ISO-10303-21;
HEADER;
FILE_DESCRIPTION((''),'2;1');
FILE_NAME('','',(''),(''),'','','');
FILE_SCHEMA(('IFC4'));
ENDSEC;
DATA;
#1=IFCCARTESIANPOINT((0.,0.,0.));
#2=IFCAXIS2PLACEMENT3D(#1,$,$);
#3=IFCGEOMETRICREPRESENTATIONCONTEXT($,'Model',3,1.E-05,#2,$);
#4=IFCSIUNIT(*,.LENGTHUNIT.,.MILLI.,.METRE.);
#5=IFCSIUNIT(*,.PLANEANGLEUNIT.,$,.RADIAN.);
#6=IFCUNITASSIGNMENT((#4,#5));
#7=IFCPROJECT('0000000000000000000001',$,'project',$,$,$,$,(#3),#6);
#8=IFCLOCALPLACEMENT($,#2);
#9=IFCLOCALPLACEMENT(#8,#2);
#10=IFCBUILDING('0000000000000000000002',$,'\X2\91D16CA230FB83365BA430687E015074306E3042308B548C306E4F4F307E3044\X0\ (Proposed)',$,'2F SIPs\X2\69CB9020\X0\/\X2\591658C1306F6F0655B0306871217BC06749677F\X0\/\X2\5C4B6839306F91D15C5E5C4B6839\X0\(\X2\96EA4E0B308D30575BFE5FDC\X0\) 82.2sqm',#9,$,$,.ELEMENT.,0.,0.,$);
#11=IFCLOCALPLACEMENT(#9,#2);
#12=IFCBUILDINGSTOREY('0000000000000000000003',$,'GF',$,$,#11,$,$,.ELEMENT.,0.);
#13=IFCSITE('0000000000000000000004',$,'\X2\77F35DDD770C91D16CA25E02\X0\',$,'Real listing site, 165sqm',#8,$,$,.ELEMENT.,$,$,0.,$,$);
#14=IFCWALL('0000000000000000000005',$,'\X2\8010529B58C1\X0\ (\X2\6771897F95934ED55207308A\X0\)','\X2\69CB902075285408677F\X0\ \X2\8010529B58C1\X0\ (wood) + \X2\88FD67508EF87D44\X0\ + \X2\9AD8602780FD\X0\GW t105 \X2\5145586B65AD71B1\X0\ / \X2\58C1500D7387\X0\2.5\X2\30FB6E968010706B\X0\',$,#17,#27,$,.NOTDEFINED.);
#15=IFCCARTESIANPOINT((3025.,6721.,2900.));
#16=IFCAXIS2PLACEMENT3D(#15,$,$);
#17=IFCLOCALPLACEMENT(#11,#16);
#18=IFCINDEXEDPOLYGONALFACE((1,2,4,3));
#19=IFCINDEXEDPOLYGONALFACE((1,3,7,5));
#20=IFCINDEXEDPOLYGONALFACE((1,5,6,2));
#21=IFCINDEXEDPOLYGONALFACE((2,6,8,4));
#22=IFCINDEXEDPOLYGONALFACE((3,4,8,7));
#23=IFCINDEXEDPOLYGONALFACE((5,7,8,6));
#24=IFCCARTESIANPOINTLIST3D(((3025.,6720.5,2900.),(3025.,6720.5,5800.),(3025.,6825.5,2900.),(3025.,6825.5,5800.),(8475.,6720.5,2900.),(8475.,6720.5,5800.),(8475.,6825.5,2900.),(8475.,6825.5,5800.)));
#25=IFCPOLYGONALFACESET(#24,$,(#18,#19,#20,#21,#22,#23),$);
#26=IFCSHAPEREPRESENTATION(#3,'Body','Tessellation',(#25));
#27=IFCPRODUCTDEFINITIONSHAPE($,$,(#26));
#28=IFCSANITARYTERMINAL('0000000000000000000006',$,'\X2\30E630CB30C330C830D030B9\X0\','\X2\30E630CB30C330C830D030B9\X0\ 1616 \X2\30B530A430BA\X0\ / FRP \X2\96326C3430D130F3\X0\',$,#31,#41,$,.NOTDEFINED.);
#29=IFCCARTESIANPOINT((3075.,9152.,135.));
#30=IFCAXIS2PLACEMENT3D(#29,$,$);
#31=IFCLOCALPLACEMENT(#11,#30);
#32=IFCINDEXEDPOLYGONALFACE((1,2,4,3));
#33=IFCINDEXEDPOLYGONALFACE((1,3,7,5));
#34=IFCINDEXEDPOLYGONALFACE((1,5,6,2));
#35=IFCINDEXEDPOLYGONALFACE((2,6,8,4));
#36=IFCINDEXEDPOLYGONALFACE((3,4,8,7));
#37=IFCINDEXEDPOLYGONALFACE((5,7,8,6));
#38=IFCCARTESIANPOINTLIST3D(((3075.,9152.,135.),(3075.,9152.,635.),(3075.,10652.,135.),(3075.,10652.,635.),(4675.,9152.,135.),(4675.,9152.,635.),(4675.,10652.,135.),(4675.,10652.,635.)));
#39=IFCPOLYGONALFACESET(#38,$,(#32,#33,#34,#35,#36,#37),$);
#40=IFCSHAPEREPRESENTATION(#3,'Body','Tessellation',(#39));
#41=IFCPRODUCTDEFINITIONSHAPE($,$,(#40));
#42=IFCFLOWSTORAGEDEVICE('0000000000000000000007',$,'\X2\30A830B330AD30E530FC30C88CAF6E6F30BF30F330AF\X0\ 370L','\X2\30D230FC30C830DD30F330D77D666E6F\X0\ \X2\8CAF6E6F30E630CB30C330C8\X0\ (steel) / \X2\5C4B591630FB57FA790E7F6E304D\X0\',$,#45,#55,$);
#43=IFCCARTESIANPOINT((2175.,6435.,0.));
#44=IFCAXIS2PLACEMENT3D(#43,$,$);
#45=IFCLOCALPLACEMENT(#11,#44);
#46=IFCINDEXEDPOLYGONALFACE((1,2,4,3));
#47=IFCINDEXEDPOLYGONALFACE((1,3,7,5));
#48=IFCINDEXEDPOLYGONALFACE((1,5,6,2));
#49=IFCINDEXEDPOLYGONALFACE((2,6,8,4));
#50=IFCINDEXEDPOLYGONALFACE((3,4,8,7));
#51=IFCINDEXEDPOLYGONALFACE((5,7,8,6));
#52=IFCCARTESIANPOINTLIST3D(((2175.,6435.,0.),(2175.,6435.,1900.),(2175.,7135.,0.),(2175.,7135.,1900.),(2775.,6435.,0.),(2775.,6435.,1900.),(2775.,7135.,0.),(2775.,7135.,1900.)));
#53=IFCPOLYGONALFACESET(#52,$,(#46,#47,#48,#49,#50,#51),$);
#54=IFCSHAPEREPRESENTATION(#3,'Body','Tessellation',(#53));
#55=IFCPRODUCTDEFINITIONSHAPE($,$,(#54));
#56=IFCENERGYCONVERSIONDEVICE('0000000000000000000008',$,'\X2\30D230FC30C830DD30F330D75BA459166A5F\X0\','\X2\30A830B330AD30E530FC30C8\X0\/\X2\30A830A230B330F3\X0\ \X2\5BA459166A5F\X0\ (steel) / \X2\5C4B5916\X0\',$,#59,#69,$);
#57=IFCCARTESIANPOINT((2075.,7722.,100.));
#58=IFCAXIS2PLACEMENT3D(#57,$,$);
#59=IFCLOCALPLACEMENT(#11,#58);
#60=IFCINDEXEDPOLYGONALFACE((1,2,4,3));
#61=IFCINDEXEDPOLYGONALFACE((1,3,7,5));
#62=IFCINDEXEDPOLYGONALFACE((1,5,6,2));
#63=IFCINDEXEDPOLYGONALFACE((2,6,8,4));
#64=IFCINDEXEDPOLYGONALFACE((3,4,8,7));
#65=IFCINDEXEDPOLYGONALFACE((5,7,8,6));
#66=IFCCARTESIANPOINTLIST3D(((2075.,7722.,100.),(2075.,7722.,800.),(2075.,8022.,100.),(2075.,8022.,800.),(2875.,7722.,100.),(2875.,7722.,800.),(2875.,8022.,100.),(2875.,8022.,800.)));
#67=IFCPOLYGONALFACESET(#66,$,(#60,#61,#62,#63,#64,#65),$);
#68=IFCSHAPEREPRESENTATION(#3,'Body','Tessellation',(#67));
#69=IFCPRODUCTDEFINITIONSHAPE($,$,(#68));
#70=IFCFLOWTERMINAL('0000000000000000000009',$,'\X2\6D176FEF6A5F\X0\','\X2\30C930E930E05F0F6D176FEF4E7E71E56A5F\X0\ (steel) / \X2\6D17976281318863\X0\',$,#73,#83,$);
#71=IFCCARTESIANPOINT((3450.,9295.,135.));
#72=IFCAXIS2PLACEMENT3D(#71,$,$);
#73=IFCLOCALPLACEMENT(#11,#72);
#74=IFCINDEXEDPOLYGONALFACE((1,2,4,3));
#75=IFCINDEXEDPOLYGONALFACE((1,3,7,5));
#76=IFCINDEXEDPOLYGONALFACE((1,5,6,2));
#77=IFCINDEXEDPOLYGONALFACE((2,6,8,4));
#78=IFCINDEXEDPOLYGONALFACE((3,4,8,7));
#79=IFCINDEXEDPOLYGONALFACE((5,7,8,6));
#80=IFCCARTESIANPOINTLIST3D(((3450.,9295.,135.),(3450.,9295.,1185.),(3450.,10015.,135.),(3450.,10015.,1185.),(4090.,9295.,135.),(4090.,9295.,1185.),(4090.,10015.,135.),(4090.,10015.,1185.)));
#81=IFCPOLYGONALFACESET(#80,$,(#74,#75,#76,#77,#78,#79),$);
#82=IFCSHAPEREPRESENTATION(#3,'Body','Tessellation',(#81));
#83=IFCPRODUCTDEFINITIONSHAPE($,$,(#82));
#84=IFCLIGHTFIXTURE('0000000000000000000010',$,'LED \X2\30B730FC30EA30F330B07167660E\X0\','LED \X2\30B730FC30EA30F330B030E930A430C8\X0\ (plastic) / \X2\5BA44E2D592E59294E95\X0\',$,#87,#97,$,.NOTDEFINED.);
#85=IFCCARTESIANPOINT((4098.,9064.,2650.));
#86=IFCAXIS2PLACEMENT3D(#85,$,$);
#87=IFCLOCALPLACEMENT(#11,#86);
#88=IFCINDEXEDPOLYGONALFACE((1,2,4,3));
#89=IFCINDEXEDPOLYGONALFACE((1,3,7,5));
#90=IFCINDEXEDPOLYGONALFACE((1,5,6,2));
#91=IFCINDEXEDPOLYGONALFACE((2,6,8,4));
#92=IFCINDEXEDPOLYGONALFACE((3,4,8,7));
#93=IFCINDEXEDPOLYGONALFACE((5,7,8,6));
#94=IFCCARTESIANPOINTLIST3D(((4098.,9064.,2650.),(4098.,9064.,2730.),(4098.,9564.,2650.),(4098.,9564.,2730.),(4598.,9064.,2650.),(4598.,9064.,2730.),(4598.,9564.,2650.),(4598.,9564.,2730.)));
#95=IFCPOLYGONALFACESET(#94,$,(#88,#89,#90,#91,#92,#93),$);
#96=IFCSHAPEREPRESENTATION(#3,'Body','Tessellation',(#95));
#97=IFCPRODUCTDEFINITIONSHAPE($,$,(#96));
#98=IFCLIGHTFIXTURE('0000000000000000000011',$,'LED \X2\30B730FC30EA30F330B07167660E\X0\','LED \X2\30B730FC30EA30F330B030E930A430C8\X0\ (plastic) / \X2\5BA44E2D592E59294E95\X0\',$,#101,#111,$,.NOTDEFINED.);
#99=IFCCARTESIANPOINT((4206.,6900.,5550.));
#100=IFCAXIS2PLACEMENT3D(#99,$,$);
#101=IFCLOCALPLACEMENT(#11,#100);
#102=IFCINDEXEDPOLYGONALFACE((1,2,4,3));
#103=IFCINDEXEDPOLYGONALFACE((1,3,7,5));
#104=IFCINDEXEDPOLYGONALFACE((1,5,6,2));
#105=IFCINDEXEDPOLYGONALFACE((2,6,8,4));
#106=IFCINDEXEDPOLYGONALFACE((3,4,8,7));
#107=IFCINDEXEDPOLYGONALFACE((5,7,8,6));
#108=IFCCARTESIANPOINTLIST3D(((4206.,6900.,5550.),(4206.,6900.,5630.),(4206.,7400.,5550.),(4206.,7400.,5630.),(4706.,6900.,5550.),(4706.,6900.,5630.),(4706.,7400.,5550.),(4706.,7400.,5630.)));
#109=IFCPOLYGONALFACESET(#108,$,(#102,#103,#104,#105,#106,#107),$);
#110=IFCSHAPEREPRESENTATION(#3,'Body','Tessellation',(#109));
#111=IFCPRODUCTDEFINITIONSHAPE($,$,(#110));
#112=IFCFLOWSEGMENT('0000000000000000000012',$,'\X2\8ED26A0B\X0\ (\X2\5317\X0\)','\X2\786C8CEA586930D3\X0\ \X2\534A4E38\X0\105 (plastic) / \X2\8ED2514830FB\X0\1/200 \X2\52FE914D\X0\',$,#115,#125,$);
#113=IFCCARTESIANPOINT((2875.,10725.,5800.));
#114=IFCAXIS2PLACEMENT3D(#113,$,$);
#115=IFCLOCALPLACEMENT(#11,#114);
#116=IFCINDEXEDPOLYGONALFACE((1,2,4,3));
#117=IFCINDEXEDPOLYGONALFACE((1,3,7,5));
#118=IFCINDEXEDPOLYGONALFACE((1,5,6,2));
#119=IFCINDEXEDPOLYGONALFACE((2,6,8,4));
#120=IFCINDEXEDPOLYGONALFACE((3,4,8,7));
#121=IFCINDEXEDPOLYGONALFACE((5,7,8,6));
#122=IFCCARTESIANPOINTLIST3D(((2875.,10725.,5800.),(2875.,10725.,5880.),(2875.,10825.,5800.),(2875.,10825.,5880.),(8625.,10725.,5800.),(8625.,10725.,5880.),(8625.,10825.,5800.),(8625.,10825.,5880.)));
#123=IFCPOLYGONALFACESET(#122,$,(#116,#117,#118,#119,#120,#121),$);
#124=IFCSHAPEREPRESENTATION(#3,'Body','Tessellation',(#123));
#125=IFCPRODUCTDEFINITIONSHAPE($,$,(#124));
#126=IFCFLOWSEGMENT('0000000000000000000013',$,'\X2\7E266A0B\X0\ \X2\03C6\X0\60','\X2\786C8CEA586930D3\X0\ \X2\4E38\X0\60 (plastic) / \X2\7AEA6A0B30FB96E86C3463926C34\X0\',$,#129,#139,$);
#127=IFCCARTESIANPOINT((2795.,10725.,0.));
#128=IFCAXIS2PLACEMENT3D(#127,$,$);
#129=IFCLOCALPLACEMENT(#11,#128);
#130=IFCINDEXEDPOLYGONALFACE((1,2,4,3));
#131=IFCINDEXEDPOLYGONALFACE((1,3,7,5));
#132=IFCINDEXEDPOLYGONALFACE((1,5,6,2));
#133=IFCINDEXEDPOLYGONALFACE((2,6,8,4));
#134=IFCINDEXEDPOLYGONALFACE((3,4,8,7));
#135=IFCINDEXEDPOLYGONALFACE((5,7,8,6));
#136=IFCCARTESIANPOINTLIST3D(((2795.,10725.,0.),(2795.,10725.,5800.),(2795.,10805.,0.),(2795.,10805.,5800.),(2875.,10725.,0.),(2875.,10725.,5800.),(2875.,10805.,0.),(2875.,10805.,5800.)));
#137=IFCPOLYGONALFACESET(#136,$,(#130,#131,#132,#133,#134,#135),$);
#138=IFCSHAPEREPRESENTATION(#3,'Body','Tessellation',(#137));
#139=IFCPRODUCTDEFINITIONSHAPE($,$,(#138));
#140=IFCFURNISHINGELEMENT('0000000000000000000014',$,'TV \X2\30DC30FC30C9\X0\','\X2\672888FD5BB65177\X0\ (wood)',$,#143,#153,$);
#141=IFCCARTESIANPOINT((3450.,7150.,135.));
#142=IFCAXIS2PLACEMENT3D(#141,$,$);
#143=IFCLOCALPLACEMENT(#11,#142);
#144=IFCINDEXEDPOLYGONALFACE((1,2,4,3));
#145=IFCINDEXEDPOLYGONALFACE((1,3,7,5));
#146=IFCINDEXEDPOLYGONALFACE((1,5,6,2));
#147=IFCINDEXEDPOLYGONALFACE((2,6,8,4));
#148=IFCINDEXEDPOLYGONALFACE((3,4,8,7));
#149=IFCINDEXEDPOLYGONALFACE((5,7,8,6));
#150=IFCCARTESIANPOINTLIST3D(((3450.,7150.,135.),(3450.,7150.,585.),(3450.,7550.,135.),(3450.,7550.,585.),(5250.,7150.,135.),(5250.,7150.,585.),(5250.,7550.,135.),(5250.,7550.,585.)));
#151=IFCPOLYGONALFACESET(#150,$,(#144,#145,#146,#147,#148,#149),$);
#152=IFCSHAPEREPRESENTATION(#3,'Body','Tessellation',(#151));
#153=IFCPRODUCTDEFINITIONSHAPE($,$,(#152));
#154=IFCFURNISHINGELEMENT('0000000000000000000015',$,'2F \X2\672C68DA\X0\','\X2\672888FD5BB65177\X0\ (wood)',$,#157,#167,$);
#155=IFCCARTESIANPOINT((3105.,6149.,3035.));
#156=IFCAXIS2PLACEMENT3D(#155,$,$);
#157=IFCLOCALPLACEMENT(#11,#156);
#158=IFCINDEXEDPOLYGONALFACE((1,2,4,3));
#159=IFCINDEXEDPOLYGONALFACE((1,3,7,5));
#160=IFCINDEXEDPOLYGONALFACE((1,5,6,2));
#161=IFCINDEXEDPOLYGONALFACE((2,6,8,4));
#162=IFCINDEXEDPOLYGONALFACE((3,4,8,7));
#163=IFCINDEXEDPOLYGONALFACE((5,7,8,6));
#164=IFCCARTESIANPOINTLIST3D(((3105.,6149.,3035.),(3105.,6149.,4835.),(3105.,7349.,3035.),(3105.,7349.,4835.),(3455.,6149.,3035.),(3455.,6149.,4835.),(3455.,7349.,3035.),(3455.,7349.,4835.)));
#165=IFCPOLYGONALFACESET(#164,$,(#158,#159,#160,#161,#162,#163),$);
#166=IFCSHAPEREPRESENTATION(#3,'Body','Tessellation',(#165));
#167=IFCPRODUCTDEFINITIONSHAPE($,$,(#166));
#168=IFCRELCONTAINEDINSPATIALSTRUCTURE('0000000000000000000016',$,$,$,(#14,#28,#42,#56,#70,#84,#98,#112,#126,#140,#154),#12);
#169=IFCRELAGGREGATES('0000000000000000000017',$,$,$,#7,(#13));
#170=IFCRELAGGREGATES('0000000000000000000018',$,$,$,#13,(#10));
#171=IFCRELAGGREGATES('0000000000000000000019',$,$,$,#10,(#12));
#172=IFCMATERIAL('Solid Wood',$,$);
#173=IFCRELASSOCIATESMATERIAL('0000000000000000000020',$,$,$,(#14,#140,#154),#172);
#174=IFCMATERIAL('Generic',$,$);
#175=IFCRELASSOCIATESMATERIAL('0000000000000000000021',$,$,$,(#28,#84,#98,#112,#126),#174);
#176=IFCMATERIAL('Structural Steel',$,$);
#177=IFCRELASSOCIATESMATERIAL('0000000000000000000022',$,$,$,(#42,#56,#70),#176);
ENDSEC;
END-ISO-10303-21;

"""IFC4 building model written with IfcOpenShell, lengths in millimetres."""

from ifc_helpers import new_model, si_unit, frame, frame_2d, origin, place, context, project, spatial, rectangle, extrude, material, element, save


model = new_model("IFC4")

# Units and contexts
model_context = context("Model", 3, precision=1e-05, world=origin())
ifc_project = project(units=[si_unit("LENGTHUNIT", "METRE", prefix="MILLI"), si_unit("PLANEANGLEUNIT", "RADIAN")], contexts=[model_context])

# Site, building, storey
site_placement = place(None, origin())
site = spatial("IfcSite", under=ifc_project, at=site_placement, Name="石川県金沢市", ObjectType="Real listing site, 165sqm", CompositionType="ELEMENT", RefElevation=0.0)
building_placement = place(site_placement, origin())
building = spatial("IfcBuilding", under=site, at=building_placement, Name="金沢・茶室と縁側のある和の住まい (Proposed)", ObjectType="2F SIPs構造/外壁は漆喰と無節杉板/屋根は金属屋根(雪下ろし対応) 82.2sqm", CompositionType="ELEMENT", ElevationOfRefHeight=0.0, ElevationOfTerrain=0.0)
storey_placement = place(building_placement, origin())
storey = spatial("IfcBuildingStorey", under=building, at=storey_placement, Name="GF", CompositionType="ELEMENT", Elevation=0.0)

# Shared definitions
ifc_material_1 = material(Name="Solid Wood")

# Wall
wall_1_placement = place(storey_placement, frame((3025.0, 6721.0, 2900.0)))
element("IfcWall", 1, at=wall_1_placement, inside=storey, material=ifc_material_1, Name="耐力壁 (東西間仕切り)", Description="構造用合板 耐力壁 (wood) + 製材軸組 + 高性能GW t105 充填断熱 / 壁倍率2.5・準耐火", PredefinedType="NOTDEFINED", context=model_context, shape_type="SweptSolid", body=[
    extrude(rectangle(XDim=5450.0, YDim=105.0, at=frame_2d((2725.0, 52.0))), frame((3025.0, 6721.0, 2900.0)), (0.0, 0.0, 1.0), 2900.0),
])

# Sanitary terminal
ifc_material_2 = material(Name="Generic")
sanitary_terminal_placement = place(storey_placement, frame((3075.0, 9152.0, 135.0)))
element("IfcSanitaryTerminal", 2, at=sanitary_terminal_placement, inside=storey, material=ifc_material_2, Name="ユニットバス", Description="ユニットバス 1616 サイズ / FRP 防水パン", PredefinedType="NOTDEFINED", context=model_context, shape_type="SweptSolid", body=[
    extrude(rectangle(XDim=1600.0, YDim=1500.0, at=frame_2d((800.0, 750.0))), frame((3075.0, 9152.0, 135.0)), (0.0, 0.0, 1.0), 500.0),
])

# Flow storage device
ifc_material_3 = material(Name="Structural Steel")
flow_storage_device_placement = place(storey_placement, frame((2175.0, 6435.0, 0.0)))
element("IfcFlowStorageDevice", 3, at=flow_storage_device_placement, inside=storey, material=ifc_material_3, Name="エコキュート貯湯タンク 370L", Description="ヒートポンプ給湯 貯湯ユニット (steel) / 屋外・基礎置き", context=model_context, shape_type="SweptSolid", body=[
    extrude(rectangle(XDim=600.0, YDim=700.0, at=frame_2d((300.0, 350.0))), frame((2175.0, 6435.0, 0.0)), (0.0, 0.0, 1.0), 1900.0),
])

# Energy conversion device
energy_conversion_device_placement = place(storey_placement, frame((2075.0, 7722.0, 100.0)))
element("IfcEnergyConversionDevice", 4, at=energy_conversion_device_placement, inside=storey, material=ifc_material_3, Name="ヒートポンプ室外機", Description="エコキュート/エアコン 室外機 (steel) / 屋外", context=model_context, shape_type="SweptSolid", body=[
    extrude(rectangle(XDim=800.0, YDim=300.0, at=frame_2d((400.0, 150.0))), frame((2075.0, 7722.0, 100.0)), (0.0, 0.0, 1.0), 700.0),
])

# Flow terminal
flow_terminal_placement = place(storey_placement, frame((3450.0, 9295.0, 135.0)))
element("IfcFlowTerminal", 5, at=flow_terminal_placement, inside=storey, material=ifc_material_3, Name="洗濯機", Description="ドラム式洗濯乾燥機 (steel) / 洗面脱衣", context=model_context, shape_type="SweptSolid", body=[
    extrude(rectangle(XDim=640.0, YDim=720.0, at=frame_2d((320.0, 360.0))), frame((3450.0, 9295.0, 135.0)), (0.0, 0.0, 1.0), 1050.0),
])

# Light fixtures
light_fixture_1_placement = place(storey_placement, frame((4098.0, 9064.0, 2650.0)))
element("IfcLightFixture", 6, at=light_fixture_1_placement, inside=storey, material=ifc_material_2, Name="LED シーリング照明", Description="LED シーリングライト (plastic) / 室中央天井", PredefinedType="NOTDEFINED", context=model_context, shape_type="SweptSolid", body=[
    extrude(rectangle(XDim=500.0, YDim=500.0, at=frame_2d((250.0, 250.0))), frame((4098.0, 9064.0, 2650.0)), (0.0, 0.0, 1.0), 80.0),
])
light_fixture_2_placement = place(storey_placement, frame((4206.0, 6900.0, 5550.0)))
element("IfcLightFixture", 7, at=light_fixture_2_placement, inside=storey, material=ifc_material_2, Name="LED シーリング照明", Description="LED シーリングライト (plastic) / 室中央天井", PredefinedType="NOTDEFINED", context=model_context, shape_type="SweptSolid", body=[
    extrude(rectangle(XDim=500.0, YDim=500.0, at=frame_2d((250.0, 250.0))), frame((4206.0, 6900.0, 5550.0)), (0.0, 0.0, 1.0), 80.0),
])

# Flow segments
flow_segment_1_placement = place(storey_placement, frame((2875.0, 10725.0, 5800.0)))
element("IfcFlowSegment", 8, at=flow_segment_1_placement, inside=storey, material=ifc_material_2, Name="軒樋 (北)", Description="硬質塩ビ 半丸105 (plastic) / 軒先・1/200 勾配", context=model_context, shape_type="SweptSolid", body=[
    extrude(rectangle(XDim=5750.0, YDim=100.0, at=frame_2d((2875.0, 50.0))), frame((2875.0, 10725.0, 5800.0)), (0.0, 0.0, 1.0), 80.0),
])
flow_segment_2_placement = place(storey_placement, frame((2795.0, 10725.0, 0.0)))
element("IfcFlowSegment", 9, at=flow_segment_2_placement, inside=storey, material=ifc_material_2, Name="縦樋 φ60", Description="硬質塩ビ 丸60 (plastic) / 竪樋・雨水排水", context=model_context, shape_type="SweptSolid", body=[
    extrude(rectangle(XDim=80.0, YDim=80.0, at=frame_2d((40.0, 40.0))), frame((2795.0, 10725.0, 0.0)), (0.0, 0.0, 1.0), 5800.0),
])

# Furnishing elements
furnishing_1_placement = place(storey_placement, frame((3450.0, 7150.0, 135.0)))
element("IfcFurnishingElement", 10, at=furnishing_1_placement, inside=storey, material=ifc_material_1, Name="TV ボード", Description="木製家具 (wood)", context=model_context, shape_type="SweptSolid", body=[
    extrude(rectangle(XDim=1800.0, YDim=400.0, at=frame_2d((900.0, 200.0))), frame((3450.0, 7150.0, 135.0)), (0.0, 0.0, 1.0), 450.0),
])
furnishing_2_placement = place(storey_placement, frame((3105.0, 6149.0, 3035.0)))
element("IfcFurnishingElement", 11, at=furnishing_2_placement, inside=storey, material=ifc_material_1, Name="2F 本棚", Description="木製家具 (wood)", context=model_context, shape_type="SweptSolid", body=[
    extrude(rectangle(XDim=350.0, YDim=1200.0, at=frame_2d((175.0, 600.0))), frame((3105.0, 6149.0, 3035.0)), (0.0, 0.0, 1.0), 1800.0),
])

save(model, "model.ifc")
